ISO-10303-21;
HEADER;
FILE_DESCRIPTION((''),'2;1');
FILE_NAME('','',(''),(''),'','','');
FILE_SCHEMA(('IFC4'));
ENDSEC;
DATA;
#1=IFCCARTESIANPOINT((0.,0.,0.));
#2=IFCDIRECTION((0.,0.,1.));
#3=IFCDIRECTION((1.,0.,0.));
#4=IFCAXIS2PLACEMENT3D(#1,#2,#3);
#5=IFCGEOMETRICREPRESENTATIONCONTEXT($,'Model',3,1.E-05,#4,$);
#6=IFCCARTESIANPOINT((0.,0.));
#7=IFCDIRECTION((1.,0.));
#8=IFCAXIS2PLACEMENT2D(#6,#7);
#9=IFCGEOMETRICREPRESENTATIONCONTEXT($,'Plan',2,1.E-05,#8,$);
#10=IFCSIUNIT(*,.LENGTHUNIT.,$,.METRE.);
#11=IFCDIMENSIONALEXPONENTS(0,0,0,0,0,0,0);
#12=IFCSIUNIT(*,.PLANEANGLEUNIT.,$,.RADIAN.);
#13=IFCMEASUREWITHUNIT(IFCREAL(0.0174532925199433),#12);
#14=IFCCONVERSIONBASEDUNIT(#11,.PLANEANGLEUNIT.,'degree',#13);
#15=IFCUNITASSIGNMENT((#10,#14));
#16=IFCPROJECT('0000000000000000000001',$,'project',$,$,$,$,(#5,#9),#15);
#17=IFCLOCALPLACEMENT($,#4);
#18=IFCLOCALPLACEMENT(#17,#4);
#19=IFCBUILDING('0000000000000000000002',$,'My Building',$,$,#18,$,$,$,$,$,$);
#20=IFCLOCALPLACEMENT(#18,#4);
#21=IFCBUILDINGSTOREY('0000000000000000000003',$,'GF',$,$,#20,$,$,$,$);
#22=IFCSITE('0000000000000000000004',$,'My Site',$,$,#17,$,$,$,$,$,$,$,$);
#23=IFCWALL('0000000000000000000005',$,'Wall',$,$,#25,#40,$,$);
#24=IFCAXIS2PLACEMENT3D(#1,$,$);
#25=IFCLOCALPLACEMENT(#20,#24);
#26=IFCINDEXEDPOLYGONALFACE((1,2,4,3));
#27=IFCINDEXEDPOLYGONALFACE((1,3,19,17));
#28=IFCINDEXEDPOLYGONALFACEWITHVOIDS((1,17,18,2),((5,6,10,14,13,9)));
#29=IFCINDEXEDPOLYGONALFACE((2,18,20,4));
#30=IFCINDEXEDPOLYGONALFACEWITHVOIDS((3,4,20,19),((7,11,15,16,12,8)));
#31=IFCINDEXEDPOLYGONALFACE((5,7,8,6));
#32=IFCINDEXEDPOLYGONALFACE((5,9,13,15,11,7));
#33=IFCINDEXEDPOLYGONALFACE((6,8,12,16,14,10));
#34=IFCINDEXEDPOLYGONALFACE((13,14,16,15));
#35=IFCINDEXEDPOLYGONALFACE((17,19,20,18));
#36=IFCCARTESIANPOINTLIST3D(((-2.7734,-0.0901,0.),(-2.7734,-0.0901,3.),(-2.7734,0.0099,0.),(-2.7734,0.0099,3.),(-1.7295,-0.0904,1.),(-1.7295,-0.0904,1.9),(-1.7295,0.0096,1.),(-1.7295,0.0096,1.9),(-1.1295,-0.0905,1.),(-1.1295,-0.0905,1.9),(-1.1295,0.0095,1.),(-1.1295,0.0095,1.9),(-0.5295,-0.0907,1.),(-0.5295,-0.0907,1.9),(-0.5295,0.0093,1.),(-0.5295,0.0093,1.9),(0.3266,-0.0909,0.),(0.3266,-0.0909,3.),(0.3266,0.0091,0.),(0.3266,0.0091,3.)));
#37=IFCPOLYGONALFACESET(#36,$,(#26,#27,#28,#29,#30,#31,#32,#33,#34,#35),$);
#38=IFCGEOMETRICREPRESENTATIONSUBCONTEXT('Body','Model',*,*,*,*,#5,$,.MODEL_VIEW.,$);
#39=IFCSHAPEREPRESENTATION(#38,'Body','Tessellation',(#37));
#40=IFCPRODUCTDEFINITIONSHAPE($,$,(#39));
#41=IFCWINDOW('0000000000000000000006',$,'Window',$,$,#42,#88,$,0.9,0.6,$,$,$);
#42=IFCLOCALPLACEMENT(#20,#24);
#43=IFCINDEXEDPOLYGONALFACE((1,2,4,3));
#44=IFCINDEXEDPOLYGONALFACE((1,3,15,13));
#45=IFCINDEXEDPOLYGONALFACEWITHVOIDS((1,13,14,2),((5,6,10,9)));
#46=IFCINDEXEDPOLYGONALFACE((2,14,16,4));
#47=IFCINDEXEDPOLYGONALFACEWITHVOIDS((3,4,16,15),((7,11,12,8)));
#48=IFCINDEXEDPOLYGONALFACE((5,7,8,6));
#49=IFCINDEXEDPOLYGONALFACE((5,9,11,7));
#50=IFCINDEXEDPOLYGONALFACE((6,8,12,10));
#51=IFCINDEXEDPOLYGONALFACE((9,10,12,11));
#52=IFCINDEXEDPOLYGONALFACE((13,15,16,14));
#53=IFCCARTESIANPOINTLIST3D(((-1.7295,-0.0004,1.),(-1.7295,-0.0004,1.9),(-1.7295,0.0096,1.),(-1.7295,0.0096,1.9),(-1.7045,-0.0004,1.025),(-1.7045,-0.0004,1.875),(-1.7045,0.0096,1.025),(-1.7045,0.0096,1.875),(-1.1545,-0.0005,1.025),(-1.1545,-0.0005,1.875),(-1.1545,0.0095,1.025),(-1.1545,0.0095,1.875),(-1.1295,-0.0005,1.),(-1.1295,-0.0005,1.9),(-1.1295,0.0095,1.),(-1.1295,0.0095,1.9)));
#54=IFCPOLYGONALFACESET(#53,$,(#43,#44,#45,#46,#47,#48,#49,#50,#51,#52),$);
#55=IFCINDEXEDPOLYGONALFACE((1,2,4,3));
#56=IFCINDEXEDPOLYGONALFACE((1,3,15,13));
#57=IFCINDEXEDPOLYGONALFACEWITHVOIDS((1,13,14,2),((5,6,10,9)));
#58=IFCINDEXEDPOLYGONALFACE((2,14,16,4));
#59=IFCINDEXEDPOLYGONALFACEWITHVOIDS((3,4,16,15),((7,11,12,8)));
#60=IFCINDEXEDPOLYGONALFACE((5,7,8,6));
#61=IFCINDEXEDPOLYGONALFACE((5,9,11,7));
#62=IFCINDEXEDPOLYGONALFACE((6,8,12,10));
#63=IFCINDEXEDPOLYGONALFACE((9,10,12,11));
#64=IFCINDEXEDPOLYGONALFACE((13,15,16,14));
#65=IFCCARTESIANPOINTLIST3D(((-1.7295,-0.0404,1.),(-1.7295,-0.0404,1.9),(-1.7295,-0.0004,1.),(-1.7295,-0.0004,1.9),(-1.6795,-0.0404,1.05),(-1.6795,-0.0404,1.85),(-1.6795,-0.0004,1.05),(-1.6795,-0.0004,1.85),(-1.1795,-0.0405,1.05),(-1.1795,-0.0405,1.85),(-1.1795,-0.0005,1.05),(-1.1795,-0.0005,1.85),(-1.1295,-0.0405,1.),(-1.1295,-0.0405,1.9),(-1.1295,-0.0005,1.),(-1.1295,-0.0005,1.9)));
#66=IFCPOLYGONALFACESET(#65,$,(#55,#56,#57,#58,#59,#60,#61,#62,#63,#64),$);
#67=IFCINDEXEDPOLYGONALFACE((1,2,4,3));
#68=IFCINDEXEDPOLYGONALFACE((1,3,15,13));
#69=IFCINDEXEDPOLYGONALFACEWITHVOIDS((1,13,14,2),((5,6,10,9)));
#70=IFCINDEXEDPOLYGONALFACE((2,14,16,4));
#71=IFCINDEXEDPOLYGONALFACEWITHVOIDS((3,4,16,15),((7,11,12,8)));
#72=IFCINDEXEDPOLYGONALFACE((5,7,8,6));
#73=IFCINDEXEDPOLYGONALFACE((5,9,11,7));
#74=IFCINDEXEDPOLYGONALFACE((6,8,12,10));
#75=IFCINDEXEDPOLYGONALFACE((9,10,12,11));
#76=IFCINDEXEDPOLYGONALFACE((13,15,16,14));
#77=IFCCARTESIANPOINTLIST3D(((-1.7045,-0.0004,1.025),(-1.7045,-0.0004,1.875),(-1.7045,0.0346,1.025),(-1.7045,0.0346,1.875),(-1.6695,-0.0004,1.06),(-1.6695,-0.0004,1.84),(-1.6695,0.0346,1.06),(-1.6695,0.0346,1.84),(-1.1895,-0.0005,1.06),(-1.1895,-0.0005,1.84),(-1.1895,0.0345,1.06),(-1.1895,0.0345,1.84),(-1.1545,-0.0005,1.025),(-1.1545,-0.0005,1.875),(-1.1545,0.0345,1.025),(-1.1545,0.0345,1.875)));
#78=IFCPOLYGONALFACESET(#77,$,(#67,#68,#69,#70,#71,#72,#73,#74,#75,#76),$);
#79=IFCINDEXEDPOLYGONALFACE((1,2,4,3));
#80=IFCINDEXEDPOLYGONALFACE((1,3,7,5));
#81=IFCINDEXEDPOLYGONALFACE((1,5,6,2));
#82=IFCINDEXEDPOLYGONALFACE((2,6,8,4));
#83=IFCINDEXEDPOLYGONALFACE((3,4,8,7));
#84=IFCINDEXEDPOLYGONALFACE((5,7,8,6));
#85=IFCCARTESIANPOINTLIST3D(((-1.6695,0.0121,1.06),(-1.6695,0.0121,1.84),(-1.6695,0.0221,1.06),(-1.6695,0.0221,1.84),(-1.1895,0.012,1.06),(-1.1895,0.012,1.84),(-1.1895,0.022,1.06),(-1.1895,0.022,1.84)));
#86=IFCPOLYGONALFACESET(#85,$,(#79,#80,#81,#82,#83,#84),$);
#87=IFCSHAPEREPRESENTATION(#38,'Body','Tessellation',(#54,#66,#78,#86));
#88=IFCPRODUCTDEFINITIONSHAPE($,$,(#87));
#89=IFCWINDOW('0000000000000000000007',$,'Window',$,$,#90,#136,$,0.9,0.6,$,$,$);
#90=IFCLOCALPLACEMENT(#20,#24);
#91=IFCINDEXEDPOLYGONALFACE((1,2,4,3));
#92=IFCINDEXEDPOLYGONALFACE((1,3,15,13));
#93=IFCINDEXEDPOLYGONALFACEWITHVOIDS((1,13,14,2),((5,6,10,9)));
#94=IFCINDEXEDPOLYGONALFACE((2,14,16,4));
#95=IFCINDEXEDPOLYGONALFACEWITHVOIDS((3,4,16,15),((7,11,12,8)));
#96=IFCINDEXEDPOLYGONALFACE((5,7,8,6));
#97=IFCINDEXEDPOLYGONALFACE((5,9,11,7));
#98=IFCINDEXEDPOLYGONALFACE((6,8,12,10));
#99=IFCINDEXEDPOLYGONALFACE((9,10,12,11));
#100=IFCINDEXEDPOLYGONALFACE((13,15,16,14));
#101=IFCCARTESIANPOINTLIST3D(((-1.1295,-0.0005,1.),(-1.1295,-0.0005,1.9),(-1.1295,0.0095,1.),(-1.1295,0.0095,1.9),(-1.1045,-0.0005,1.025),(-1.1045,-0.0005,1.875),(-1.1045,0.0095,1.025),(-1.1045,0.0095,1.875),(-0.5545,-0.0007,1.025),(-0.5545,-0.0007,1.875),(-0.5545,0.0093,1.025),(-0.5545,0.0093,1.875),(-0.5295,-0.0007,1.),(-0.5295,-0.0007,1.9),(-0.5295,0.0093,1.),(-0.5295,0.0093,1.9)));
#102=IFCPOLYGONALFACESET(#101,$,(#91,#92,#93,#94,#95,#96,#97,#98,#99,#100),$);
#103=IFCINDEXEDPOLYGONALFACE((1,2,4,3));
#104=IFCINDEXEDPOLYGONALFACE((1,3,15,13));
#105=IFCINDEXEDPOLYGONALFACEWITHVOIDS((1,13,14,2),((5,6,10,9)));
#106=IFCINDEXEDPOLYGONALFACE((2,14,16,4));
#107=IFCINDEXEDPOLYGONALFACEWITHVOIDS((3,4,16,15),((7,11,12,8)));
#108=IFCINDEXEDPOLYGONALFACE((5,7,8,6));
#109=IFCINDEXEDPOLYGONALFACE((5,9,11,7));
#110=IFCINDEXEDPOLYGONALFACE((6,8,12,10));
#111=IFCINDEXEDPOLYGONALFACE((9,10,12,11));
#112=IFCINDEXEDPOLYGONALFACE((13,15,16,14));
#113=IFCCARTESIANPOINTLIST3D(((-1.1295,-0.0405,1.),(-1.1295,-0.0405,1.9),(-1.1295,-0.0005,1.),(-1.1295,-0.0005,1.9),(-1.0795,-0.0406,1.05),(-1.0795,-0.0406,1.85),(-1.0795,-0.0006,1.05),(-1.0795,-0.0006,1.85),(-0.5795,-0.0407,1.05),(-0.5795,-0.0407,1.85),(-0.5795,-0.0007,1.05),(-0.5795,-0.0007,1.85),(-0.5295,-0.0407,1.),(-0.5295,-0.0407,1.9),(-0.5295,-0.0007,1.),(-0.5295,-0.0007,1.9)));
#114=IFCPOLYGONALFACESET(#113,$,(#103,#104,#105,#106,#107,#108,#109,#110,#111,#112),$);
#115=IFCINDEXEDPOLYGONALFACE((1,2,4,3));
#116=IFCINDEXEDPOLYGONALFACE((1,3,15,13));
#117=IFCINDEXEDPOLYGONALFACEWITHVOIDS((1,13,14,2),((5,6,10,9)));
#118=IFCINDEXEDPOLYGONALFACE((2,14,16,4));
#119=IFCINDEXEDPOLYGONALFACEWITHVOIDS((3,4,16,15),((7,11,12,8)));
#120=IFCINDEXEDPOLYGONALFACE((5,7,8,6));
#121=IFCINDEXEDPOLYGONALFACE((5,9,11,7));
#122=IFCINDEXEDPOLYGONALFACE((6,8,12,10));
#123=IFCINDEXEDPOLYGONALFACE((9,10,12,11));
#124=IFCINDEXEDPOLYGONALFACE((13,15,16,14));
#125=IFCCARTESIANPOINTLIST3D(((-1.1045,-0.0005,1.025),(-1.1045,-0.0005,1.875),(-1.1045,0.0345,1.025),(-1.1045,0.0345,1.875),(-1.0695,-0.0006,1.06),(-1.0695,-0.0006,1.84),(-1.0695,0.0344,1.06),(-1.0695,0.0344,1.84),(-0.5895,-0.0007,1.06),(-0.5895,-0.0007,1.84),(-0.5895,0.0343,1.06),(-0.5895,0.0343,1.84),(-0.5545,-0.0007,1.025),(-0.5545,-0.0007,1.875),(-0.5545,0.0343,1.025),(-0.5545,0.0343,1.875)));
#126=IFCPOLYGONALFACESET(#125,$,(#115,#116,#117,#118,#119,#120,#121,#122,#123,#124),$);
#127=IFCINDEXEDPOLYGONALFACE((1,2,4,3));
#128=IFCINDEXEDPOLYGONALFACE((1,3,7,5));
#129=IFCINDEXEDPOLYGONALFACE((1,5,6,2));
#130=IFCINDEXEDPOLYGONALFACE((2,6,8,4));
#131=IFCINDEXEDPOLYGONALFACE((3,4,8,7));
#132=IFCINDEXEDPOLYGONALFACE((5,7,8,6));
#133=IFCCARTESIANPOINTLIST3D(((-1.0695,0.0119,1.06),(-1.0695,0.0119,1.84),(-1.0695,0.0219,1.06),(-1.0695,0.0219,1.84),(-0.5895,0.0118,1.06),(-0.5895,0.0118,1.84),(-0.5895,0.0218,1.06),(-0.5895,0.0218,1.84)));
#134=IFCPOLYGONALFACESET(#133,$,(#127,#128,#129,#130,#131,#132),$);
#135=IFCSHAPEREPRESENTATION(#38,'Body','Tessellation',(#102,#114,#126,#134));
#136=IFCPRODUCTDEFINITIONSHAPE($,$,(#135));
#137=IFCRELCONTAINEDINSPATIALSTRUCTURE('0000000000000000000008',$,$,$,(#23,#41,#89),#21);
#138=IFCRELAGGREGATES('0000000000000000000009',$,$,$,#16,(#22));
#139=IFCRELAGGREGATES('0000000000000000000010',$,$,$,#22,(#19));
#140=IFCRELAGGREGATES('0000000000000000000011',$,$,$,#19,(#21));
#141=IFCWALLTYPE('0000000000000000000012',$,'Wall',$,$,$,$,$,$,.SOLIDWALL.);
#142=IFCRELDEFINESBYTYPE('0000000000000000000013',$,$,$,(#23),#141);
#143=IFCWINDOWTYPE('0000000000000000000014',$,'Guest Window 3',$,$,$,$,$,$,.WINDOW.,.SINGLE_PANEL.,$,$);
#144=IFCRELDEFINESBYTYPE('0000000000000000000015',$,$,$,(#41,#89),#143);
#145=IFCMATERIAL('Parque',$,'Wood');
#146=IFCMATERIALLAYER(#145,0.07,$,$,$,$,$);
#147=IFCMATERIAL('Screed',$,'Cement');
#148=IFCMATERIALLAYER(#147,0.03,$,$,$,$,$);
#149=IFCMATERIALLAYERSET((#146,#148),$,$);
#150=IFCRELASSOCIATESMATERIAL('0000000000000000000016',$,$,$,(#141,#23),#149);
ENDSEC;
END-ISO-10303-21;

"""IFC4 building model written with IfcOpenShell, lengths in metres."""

from ifc_helpers import new_model, entity, si_unit, converted_unit, frame, origin_with_axes, origin_2d_with_axis, place, context, subcontext, project, spatial, line, indexed_curve, outline, extrude, shape, source, transform, mapped, material, layer, layer_set, layer_usage, type_object, type_shapes, element, fill, save


model = new_model("IFC4")

# Units and contexts
model_context = context("Model", 3, precision=1e-05, world=origin_with_axes())
plan_context = context("Plan", 2, precision=1e-05, world=origin_2d_with_axis())
body_context_1 = subcontext(model_context, "Body", "Model", "MODEL_VIEW")
body_context_2 = subcontext(plan_context, "Body", "Plan", "PLAN_VIEW")
ifc_project = project(units=[si_unit("LENGTHUNIT", "METRE"), converted_unit("PLANEANGLEUNIT", "degree", entity("IfcReal", 0.0174532925199433), si_unit("PLANEANGLEUNIT", "RADIAN"), dimensions=[0, 0, 0, 0, 0, 0, 0])], contexts=[model_context, plan_context])

# Site, building, storey
site_placement = place(None, origin_with_axes())
site = spatial("IfcSite", under=ifc_project, at=site_placement, Name="My Site")
building_placement = place(site_placement, origin_with_axes())
building = spatial("IfcBuilding", under=site, at=building_placement, Name="My Building")
storey_placement = place(building_placement, origin_with_axes())
storey = spatial("IfcBuildingStorey", under=building, at=storey_placement, Name="GF")

# Shared definitions
ifc_material_1 = material(Name="Parque", Category="Wood")
ifc_layer_1 = layer(ifc_material_1, 0.07)
ifc_material_2 = material(Name="Screed", Category="Cement")
ifc_layer_2 = layer(ifc_material_2, 0.03)
ifc_layer_set_1 = layer_set([ifc_layer_1, ifc_layer_2])
wall_type = type_object("IfcWallType", Name="Wall", PredefinedType="SOLIDWALL", material=ifc_layer_set_1)

# Wall, openings, windows
ifc_layer_usage_1 = layer_usage(ifc_layer_set_1, "AXIS2", "POSITIVE", 0.0)
wall_1_placement = place(storey_placement, frame((-2.7734, -0.0901, 0.0), z_axis=(0.0, 0.0, 1.0), x_axis=(1.0, -0.000264, 0.0)))
wall_1 = element("IfcWall", 1, at=wall_1_placement, inside=storey, type_object=wall_type, material=ifc_layer_usage_1, Name="Wall", context=body_context_1, shape_type="SweptSolid", body=[
    extrude(outline(indexed_curve([(0.0, 0.0), (0.0, 0.1), (3.1, 0.1), (3.1, 0.0)], segments=[line(1, 2, 3, 4, 1)])), origin_with_axes(), (0.0, 0.0, 1.0), 3.0),
])
shared_shape_1 = source(origin_with_axes(), body_context_1, "Body", "SweptSolid", [
    extrude(outline(indexed_curve([(0.0, 0.0), (0.6, 0.0), (0.6, 0.9), (0.0, 0.9)], segments=[line(1, 2, 3, 4, 1)])), frame((0.0, -0.6, 0.0), z_axis=(0.0, -1.0, 0.0), x_axis=(1.0, 0.0, 0.0)), (0.0, 0.0, -1.0), 1.2),
])
opening_1_placement = place(wall_1_placement, frame((1.0439, 0.0, 1.0), z_axis=(0.0, 0.0, 1.0), x_axis=(1.0, 0.0, 0.0)))
opening_1 = element("IfcOpeningElement", 2, at=opening_1_placement, cuts=wall_1, PredefinedType="OPENING", context=body_context_1, shape_type="MappedRepresentation", body=[
    mapped(shared_shape_1, transform((0.0, 0.0, 0.0), x_axis=(1.0, 0.0, 0.0), y_axis=(0.0, 1.0, 0.0), z_axis=(0.0, 0.0, 1.0), scale=1.0)),
])
opening_2_placement = place(wall_1_placement, frame((1.6439, 0.0, 1.0), z_axis=(0.0, 0.0, 1.0), x_axis=(1.0, 0.0, 0.0)))
opening_2 = element("IfcOpeningElement", 3, at=opening_2_placement, cuts=wall_1, PredefinedType="OPENING", context=body_context_1, shape_type="MappedRepresentation", body=[
    mapped(shared_shape_1, transform((0.0, 0.0, 0.0), x_axis=(1.0, 0.0, 0.0), y_axis=(0.0, 1.0, 0.0), z_axis=(0.0, 0.0, 1.0), scale=1.0)),
])
window_type_1 = type_object("IfcWindowType", Name="Guest Window 3", PartitioningType="SINGLE_PANEL", PredefinedType="WINDOW")
shared_shape_2 = source(origin_with_axes(), body_context_1, "Body", "SweptSolid", [
    extrude(outline(indexed_curve([(0.0, 0.0), (0.6, 0.0), (0.6, 0.9), (0.0, 0.9)], segments=[line(1, 2, 3, 4, 1)]), holes=[indexed_curve([(0.025, 0.025), (0.575, 0.025), (0.575, 0.875), (0.025, 0.875)], segments=[line(1, 2, 3, 4, 1)])]), frame((0.0, 0.09, 0.0), z_axis=(0.0, -1.0, 0.0), x_axis=(1.0, 0.0, 0.0)), (0.0, 0.0, -1.0), 0.01),
    extrude(outline(indexed_curve([(0.0, 0.0), (0.6, 0.0), (0.6, 0.9), (0.0, 0.9)], segments=[line(1, 2, 3, 4, 1)]), holes=[indexed_curve([(0.05, 0.05), (0.55, 0.05), (0.55, 0.85), (0.05, 0.85)], segments=[line(1, 2, 3, 4, 1)])]), frame((0.0, 0.05, 0.0), z_axis=(0.0, -1.0, 0.0), x_axis=(1.0, 0.0, 0.0)), (0.0, 0.0, -1.0), 0.04),
    extrude(outline(indexed_curve([(0.0, 0.0), (0.55, 0.0), (0.55, 0.85), (0.0, 0.85)], segments=[line(1, 2, 3, 4, 1)]), holes=[indexed_curve([(0.035, 0.035), (0.515, 0.035), (0.515, 0.815), (0.035, 0.815)], segments=[line(1, 2, 3, 4, 1)])]), frame((0.025, 0.09, 0.025), z_axis=(0.0, -1.0, 0.0), x_axis=(1.0, 0.0, 0.0)), (0.0, 0.0, -1.0), 0.035),
    extrude(outline(indexed_curve([(0.035, 0.035), (0.515, 0.035), (0.515, 0.815), (0.035, 0.815)], segments=[line(1, 2, 3, 4, 1)])), frame((0.025, 0.1025, 0.025), z_axis=(0.0, -1.0, 0.0), x_axis=(1.0, 0.0, 0.0)), (0.0, 0.0, -1.0), 0.01),
])
shared_shape_3 = source(origin_with_axes(), body_context_2, "Body", "Curve2D", [
    entity("IfcIndexedPolyCurve", entity("IfcCartesianPointList2D", [[0.05, 0.05], [0.55, 0.05]])),
    entity("IfcIndexedPolyCurve", entity("IfcCartesianPointList2D", [[0.0, 0.1], [0.025, 0.1], [0.025, 0.09], [0.05, 0.09], [0.05, 0.05], [0.0, 0.05]]), [entity("IfcLineIndex", [1, 2, 3, 4, 5, 6, 1])]),
    entity("IfcIndexedPolyCurve", entity("IfcCartesianPointList2D", [[0.6, 0.1], [0.575, 0.1], [0.575, 0.09], [0.55, 0.09], [0.55, 0.05], [0.6, 0.05]]), [entity("IfcLineIndex", [1, 2, 3, 4, 5, 6, 1])]),
    entity("IfcIndexedPolyCurve", entity("IfcCartesianPointList2D", [[0.025, 0.09], [0.06, 0.09], [0.06, 0.125], [0.025, 0.125]]), [entity("IfcLineIndex", [1, 2, 3, 4, 1])]),
    entity("IfcIndexedPolyCurve", entity("IfcCartesianPointList2D", [[0.575, 0.09], [0.54, 0.09], [0.54, 0.125], [0.575, 0.125]]), [entity("IfcLineIndex", [1, 2, 3, 4, 1])]),
    entity("IfcIndexedPolyCurve", entity("IfcCartesianPointList2D", [[0.06, 0.09], [0.54, 0.09]])),
    entity("IfcIndexedPolyCurve", entity("IfcCartesianPointList2D", [[0.06, 0.125], [0.54, 0.125]])),
    entity("IfcIndexedPolyCurve", entity("IfcCartesianPointList2D", [[0.06, 0.1075], [0.54, 0.1075]])),
])
type_shapes(window_type_1, [shared_shape_2, shared_shape_3])
window_1_placement = place(opening_1_placement, frame((0.0, 0.0, 0.0), z_axis=(0.0, 0.0, 1.0), x_axis=(1.0, 0.0, 0.0)))
window_1 = element("IfcWindow", 4, at=window_1_placement, inside=storey, type_object=window_type_1, Name="Window", OverallHeight=0.9, OverallWidth=0.6, shapes=[
    shape(body_context_1, "Body", "MappedRepresentation", [mapped(shared_shape_2, transform((0.0, 0.0, 0.0), x_axis=(1.0, 0.0, 0.0), y_axis=(0.0, 1.0, 0.0), z_axis=(0.0, 0.0, 1.0), scale=1.0))]),
    shape(body_context_2, "Body", "MappedRepresentation", [mapped(shared_shape_3, transform((0.0, 0.0, 0.0), x_axis=(1.0, 0.0, 0.0), y_axis=(0.0, 1.0, 0.0), z_axis=(0.0, 0.0, 1.0), scale=1.0))]),
])
fill(opening_1, window_1)
window_2_placement = place(opening_2_placement, frame((0.0, 0.0, 0.0), z_axis=(0.0, 0.0, 1.0), x_axis=(1.0, 0.0, 0.0)))
window_2 = element("IfcWindow", 5, at=window_2_placement, inside=storey, type_object=window_type_1, Name="Window", OverallHeight=0.9, OverallWidth=0.6, shapes=[
    shape(body_context_1, "Body", "MappedRepresentation", [mapped(shared_shape_2, transform((0.0, 0.0, 0.0), x_axis=(1.0, 0.0, 0.0), y_axis=(0.0, 1.0, 0.0), z_axis=(0.0, 0.0, 1.0), scale=1.0))]),
    shape(body_context_2, "Body", "MappedRepresentation", [mapped(shared_shape_3, transform((0.0, 0.0, 0.0), x_axis=(1.0, 0.0, 0.0), y_axis=(0.0, 1.0, 0.0), z_axis=(0.0, 0.0, 1.0), scale=1.0))]),
])
fill(opening_2, window_2)

save(model, "model.ifc")
